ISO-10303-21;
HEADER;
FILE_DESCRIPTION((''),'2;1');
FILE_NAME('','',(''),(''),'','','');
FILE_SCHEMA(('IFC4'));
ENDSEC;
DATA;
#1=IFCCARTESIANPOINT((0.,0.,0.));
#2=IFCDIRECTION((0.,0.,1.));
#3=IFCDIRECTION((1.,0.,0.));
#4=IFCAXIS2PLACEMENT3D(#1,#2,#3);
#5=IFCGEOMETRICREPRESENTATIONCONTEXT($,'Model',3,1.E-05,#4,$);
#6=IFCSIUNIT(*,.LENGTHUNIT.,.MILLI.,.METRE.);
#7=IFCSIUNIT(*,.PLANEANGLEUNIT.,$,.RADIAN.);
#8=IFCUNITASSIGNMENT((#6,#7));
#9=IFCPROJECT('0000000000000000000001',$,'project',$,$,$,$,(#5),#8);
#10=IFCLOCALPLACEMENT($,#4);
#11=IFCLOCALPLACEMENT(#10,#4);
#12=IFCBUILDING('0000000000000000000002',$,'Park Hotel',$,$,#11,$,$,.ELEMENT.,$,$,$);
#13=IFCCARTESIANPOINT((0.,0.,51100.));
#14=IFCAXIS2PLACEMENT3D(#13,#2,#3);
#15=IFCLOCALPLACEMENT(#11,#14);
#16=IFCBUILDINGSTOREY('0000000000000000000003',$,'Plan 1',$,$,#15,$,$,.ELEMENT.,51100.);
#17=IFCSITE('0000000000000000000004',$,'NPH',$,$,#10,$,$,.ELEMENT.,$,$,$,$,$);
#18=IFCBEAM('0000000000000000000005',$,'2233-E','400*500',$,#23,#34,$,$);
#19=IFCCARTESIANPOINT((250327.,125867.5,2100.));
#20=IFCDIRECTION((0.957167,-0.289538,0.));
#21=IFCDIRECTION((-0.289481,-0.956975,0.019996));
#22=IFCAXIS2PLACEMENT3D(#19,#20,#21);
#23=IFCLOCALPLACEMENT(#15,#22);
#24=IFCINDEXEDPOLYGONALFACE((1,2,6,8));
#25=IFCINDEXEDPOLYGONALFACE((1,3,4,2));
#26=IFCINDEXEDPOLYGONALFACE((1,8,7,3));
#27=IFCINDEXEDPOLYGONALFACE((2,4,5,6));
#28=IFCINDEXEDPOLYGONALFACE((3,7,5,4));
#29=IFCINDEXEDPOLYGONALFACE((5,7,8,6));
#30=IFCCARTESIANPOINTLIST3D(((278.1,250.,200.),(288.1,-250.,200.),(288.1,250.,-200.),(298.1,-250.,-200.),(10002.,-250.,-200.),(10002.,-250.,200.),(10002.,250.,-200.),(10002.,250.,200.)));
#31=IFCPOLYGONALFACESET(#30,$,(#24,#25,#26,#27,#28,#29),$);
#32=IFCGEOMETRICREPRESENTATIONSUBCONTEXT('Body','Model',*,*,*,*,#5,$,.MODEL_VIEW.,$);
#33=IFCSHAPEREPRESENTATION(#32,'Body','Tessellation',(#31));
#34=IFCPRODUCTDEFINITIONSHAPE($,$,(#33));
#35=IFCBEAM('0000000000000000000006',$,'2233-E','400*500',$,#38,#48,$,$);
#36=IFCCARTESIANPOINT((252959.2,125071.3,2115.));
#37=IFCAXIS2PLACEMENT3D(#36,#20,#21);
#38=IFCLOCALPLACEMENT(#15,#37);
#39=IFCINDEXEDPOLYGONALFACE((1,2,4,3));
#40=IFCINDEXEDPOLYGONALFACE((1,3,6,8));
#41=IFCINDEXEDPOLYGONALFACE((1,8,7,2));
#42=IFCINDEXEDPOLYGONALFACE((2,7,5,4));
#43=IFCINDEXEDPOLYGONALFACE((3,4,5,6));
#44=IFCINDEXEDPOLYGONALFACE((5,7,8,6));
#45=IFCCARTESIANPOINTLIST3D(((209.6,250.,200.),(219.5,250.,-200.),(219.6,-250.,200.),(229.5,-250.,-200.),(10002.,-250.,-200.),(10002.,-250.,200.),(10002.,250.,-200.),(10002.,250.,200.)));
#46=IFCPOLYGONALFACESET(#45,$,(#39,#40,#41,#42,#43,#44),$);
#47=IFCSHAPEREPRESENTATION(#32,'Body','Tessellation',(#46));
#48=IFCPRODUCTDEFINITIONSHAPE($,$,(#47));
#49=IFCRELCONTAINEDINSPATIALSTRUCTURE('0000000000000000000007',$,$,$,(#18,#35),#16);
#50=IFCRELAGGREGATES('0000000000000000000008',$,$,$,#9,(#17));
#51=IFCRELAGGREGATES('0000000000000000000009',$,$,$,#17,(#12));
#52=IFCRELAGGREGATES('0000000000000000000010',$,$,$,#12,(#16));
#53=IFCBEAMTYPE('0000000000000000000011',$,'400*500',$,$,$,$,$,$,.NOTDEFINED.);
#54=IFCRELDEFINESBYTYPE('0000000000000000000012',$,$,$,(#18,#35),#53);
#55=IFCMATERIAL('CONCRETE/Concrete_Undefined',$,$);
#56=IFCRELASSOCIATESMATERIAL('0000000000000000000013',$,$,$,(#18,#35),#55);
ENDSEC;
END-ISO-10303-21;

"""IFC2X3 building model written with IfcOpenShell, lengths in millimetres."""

from ifc_helpers import new_model, si_unit, frame, origin_with_axes, origin_2d_with_axis, place, context, subcontext, project, spatial, rectangle, extrude, clip, halfspace, material, type_object, element, save


model = new_model("IFC2X3")

# Units and contexts
model_context = context("Model", 3, precision=1e-05, world=origin_with_axes())
body_context = subcontext(model_context, "Body", "Model", "MODEL_VIEW")
ifc_project = project(units=[si_unit("LENGTHUNIT", "METRE", prefix="MILLI"), si_unit("PLANEANGLEUNIT", "RADIAN")], contexts=[model_context])

# Site, building, storey
site_placement = place(None, origin_with_axes())
site = spatial("IfcSite", under=ifc_project, at=site_placement, Name="NPH", CompositionType="ELEMENT")
building_placement = place(site_placement, origin_with_axes())
building = spatial("IfcBuilding", under=site, at=building_placement, Name="Park Hotel", CompositionType="ELEMENT")
storey_placement = place(building_placement, frame((0.0, 0.0, 51100.0), z_axis=(0.0, 0.0, 1.0), x_axis=(1.0, 0.0, 0.0)))
storey = spatial("IfcBuildingStorey", under=building, at=storey_placement, Name="Plan 1", CompositionType="ELEMENT", Elevation=51100.0)

# Beams
ifc_material_1 = material(Name="CONCRETE/Concrete_Undefined")
beam_type_1 = type_object("IfcBeamType", Name="400*500", PredefinedType="NOTDEFINED")
beam_1_placement = place(storey_placement, frame((250327.0, 125867.5, 2100.0), z_axis=(0.957167, -0.289538, 0.0), x_axis=(-0.289481, -0.956975, 0.019996)))
element("IfcBeam", 1, at=beam_1_placement, inside=storey, type_object=beam_type_1, material=ifc_material_1, Name="2233-E", Description="400*500", context=body_context, shape_type="Clipping", body=[
    clip(extrude(rectangle(XDim=500.0, YDim=400.0, at=origin_2d_with_axis()), frame((10002.0, 0.0, 0.0), z_axis=(-1.0, 0.0, 0.0), x_axis=(0.0, -1.0, 0.0)), (0.0, 0.0, 1.0), 10002.0), halfspace(frame((288.1, -250.0, 200.0), z_axis=(-0.99949, -0.01999, -0.024903), x_axis=(0.024908, 0.0, -0.99969)), False)),
])
beam_2_placement = place(storey_placement, frame((252959.2, 125071.3, 2115.0), z_axis=(0.957167, -0.289538, 0.0), x_axis=(-0.289481, -0.956975, 0.019996)))
element("IfcBeam", 2, at=beam_2_placement, inside=storey, type_object=beam_type_1, material=ifc_material_1, Name="2233-E", Description="400*500", context=body_context, shape_type="Clipping", body=[
    clip(extrude(rectangle(XDim=500.0, YDim=400.0, at=origin_2d_with_axis()), frame((10002.0, 0.0, 0.0), z_axis=(-1.0, 0.0, 0.0), x_axis=(0.0, -1.0, 0.0)), (0.0, 0.0, 1.0), 10002.0), halfspace(frame((219.6, -250.0, 200.0), z_axis=(-0.99949, -0.01999, -0.024903), x_axis=(0.024908, 0.0, -0.99969)), False)),
])

save(model, "model.ifc")
